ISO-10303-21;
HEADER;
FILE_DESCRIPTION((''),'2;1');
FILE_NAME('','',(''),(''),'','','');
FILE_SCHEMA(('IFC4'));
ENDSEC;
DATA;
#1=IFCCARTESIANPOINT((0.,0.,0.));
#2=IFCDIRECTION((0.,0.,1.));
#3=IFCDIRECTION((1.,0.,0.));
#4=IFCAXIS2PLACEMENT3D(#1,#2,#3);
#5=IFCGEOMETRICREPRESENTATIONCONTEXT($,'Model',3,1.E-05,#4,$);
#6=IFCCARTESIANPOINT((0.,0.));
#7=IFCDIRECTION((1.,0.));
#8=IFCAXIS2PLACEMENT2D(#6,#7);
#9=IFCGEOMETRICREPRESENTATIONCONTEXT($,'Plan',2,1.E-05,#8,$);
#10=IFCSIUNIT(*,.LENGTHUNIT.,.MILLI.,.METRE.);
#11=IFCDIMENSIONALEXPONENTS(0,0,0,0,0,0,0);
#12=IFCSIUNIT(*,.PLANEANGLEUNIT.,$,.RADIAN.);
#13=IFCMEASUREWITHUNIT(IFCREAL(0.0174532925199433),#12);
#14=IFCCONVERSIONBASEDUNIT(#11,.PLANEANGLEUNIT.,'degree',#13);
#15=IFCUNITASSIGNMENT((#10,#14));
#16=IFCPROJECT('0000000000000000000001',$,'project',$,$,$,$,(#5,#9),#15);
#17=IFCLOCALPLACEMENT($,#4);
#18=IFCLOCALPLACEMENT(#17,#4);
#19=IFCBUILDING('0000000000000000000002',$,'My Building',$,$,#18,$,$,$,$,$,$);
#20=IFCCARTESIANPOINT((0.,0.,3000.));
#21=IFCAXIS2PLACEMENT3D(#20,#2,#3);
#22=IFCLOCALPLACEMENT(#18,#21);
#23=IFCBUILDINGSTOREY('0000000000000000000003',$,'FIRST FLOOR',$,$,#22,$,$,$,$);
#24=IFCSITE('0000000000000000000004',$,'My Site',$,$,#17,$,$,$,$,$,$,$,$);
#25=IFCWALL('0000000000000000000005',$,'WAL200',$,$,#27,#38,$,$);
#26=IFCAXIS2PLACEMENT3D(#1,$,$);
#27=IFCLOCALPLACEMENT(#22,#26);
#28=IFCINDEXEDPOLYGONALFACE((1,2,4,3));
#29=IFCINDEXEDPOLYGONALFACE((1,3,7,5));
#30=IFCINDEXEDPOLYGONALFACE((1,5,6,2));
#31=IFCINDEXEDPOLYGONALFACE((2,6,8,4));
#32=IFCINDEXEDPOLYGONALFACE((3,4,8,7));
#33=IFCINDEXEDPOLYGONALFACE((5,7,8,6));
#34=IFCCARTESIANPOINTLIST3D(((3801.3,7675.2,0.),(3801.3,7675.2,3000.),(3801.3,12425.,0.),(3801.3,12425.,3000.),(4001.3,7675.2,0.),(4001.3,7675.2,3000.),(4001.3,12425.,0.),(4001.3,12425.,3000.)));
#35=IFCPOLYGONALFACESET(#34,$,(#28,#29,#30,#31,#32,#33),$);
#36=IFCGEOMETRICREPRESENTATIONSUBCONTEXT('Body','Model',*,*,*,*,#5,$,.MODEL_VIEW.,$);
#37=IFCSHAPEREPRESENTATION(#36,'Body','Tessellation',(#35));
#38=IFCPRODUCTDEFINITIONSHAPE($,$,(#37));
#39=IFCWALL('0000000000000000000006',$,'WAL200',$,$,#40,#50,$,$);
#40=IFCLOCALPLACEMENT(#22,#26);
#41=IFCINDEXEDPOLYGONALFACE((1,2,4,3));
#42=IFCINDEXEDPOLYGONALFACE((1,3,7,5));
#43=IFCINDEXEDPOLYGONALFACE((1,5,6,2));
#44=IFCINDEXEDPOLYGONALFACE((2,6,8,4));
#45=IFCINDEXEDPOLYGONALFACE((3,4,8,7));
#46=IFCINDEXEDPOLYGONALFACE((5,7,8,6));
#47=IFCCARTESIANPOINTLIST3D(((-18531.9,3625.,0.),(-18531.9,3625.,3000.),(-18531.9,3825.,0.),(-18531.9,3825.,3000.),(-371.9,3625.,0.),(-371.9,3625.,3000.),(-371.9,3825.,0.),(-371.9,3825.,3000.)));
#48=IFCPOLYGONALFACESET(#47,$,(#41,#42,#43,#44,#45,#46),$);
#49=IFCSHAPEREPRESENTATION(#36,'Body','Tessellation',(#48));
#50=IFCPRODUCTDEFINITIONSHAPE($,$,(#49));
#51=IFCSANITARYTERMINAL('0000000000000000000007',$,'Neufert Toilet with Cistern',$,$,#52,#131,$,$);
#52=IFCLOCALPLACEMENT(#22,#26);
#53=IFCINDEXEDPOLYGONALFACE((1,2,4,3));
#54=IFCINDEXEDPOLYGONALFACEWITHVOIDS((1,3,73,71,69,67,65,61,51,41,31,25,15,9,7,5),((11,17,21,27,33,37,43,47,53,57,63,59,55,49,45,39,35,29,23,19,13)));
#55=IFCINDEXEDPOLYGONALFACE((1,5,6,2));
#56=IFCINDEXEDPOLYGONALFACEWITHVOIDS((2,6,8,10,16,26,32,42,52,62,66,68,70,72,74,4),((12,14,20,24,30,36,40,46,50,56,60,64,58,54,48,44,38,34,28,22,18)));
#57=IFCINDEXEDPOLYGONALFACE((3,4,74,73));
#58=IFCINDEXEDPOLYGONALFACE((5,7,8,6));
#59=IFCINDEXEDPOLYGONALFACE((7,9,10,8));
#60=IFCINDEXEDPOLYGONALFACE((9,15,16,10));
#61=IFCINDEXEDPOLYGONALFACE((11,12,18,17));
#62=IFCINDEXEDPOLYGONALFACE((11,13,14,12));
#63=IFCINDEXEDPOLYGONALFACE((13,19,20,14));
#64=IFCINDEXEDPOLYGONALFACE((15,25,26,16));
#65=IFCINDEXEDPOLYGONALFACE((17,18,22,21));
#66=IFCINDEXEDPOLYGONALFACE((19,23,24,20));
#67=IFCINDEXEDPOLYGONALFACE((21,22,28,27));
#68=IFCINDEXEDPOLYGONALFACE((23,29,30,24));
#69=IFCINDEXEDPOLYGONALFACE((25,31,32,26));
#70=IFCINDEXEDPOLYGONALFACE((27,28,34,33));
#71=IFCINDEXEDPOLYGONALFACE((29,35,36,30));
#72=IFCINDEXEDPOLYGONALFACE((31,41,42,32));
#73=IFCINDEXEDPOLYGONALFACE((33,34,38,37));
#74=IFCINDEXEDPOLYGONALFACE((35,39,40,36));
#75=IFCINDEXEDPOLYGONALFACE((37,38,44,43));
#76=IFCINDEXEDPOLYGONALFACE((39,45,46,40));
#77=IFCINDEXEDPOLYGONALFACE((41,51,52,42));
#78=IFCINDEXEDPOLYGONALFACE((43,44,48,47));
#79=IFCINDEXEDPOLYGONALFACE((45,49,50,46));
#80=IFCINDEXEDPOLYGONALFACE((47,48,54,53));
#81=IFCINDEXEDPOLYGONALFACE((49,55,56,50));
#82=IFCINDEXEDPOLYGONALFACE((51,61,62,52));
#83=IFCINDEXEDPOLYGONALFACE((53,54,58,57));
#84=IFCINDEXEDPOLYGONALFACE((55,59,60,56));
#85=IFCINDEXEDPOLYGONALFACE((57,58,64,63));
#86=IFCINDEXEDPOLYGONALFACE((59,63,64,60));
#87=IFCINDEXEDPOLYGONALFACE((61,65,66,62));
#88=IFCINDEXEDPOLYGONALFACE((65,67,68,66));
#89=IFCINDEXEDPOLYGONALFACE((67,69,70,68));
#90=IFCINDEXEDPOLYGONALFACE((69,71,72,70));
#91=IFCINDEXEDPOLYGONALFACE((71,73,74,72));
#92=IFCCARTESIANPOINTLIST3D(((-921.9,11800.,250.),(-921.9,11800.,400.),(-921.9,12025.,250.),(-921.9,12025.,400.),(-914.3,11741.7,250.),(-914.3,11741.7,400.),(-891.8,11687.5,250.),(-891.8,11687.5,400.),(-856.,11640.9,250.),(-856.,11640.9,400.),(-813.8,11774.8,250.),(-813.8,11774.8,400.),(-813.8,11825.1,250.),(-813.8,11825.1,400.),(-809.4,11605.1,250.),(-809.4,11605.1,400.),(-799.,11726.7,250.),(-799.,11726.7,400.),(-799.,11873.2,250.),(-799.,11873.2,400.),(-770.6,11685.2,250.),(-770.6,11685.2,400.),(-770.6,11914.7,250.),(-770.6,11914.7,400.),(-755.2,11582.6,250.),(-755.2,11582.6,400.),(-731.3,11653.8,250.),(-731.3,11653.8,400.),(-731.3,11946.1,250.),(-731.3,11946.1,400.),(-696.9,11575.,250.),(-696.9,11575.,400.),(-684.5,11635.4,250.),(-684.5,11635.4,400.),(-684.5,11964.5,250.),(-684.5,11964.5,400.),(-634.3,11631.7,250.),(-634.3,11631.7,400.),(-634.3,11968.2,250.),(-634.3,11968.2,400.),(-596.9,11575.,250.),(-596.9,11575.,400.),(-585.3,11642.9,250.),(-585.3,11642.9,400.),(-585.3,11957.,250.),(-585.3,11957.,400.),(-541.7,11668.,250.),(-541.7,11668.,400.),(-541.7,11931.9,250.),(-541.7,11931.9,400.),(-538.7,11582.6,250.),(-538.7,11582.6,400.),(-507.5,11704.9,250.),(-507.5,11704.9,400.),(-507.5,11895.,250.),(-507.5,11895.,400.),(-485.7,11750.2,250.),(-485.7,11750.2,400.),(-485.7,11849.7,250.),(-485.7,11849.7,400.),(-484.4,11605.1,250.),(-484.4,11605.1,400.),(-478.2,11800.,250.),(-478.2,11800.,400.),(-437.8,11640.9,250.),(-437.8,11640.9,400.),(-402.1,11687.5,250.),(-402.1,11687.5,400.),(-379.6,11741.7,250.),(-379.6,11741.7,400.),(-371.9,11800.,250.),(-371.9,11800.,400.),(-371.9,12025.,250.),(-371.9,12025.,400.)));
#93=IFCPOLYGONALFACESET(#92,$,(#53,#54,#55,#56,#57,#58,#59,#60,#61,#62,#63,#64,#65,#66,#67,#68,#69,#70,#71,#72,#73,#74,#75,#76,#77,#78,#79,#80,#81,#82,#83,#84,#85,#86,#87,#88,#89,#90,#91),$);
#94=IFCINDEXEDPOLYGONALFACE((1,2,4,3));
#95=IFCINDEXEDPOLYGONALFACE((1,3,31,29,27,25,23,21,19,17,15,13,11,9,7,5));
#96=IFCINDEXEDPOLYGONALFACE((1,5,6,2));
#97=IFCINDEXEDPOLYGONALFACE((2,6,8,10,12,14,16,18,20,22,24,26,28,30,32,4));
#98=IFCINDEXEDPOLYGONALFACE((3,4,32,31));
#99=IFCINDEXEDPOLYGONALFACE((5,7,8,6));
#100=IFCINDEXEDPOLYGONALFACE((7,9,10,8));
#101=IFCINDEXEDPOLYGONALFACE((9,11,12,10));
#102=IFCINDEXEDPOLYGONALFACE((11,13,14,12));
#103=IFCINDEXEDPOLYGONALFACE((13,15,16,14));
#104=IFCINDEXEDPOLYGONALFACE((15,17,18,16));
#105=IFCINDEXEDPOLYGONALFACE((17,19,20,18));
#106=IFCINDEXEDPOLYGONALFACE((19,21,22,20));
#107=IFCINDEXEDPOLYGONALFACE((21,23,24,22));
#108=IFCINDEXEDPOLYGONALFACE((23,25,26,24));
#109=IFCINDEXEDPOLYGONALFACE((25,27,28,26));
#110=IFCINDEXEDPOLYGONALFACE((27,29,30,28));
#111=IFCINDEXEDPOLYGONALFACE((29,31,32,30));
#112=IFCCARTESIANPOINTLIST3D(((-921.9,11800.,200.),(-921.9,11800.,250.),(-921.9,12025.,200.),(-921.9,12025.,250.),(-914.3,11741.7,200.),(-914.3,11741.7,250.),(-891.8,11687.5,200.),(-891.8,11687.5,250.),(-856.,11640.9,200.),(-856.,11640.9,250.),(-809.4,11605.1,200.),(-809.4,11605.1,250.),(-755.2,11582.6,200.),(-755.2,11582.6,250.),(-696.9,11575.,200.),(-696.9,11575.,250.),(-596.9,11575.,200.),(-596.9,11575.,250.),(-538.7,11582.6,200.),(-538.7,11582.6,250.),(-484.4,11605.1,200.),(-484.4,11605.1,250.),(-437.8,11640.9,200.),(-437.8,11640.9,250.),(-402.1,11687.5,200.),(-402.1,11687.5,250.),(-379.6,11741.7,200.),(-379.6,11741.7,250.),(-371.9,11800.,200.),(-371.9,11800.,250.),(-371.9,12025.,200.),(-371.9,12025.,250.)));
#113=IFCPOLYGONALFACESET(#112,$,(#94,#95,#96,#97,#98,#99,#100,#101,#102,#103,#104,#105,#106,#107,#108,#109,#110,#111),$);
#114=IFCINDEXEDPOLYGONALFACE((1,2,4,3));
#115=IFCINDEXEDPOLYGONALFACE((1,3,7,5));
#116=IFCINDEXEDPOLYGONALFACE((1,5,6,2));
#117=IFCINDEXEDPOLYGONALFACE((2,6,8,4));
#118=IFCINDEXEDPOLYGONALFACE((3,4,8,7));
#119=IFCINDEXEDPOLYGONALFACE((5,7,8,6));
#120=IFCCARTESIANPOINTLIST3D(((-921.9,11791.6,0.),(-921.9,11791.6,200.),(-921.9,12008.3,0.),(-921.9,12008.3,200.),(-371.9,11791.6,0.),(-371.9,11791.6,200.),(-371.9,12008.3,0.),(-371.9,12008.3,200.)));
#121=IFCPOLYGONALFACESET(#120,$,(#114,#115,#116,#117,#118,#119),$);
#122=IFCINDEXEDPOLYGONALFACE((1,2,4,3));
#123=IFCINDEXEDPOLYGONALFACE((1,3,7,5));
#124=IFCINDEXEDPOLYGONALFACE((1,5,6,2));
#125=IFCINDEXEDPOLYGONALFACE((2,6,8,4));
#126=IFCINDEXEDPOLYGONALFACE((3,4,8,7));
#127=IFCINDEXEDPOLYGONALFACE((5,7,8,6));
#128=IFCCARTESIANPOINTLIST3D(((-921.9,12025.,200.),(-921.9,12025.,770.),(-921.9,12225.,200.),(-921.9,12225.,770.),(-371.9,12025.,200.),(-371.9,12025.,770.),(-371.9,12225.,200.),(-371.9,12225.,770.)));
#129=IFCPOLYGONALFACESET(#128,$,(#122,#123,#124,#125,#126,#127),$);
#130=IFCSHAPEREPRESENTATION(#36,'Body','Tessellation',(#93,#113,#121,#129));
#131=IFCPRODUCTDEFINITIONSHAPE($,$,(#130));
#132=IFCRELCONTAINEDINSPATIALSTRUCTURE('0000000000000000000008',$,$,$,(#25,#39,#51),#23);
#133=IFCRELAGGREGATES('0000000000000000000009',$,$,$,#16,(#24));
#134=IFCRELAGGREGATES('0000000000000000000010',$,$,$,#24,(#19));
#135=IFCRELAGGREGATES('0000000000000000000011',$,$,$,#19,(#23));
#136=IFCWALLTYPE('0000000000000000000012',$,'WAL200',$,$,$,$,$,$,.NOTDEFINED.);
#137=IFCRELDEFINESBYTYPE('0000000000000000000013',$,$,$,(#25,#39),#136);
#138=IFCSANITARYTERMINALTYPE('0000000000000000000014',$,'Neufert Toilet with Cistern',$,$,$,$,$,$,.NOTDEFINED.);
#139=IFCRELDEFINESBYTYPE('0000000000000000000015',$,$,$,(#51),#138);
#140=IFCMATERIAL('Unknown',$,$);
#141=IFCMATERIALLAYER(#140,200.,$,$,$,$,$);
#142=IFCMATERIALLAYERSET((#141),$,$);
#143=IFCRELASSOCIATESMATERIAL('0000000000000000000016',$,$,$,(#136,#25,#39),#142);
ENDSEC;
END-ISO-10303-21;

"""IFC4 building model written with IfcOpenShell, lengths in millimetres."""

from ifc_helpers import new_model, entity, si_unit, converted_unit, frame, frame_2d, origin_with_axes, origin_2d_with_axis, place, context, subcontext, project, spatial, line, arc, indexed_curve, circle_curve, outline, extrude, shape, source, transform, mapped, material, layer, layer_set, layer_usage, type_object, type_shapes, element, save


model = new_model("IFC4")

# Units and contexts
model_context = context("Model", 3, precision=1e-05, world=origin_with_axes())
plan_context = context("Plan", 2, precision=1e-05, world=origin_2d_with_axis())
body_context_1 = subcontext(model_context, "Body", "Model", "MODEL_VIEW")
body_context_2 = subcontext(plan_context, "Body", "Plan", "PLAN_VIEW")
ifc_project = project(units=[si_unit("LENGTHUNIT", "METRE", prefix="MILLI"), converted_unit("PLANEANGLEUNIT", "degree", entity("IfcReal", 0.0174532925199433), si_unit("PLANEANGLEUNIT", "RADIAN"), dimensions=[0, 0, 0, 0, 0, 0, 0])], contexts=[model_context, plan_context])

# Site, building, storey
site_placement = place(None, origin_with_axes())
site = spatial("IfcSite", under=ifc_project, at=site_placement, Name="My Site")
building_placement = place(site_placement, origin_with_axes())
building = spatial("IfcBuilding", under=site, at=building_placement, Name="My Building")
storey_placement = place(building_placement, frame((0.0, 0.0, 3000.0), z_axis=(0.0, 0.0, 1.0), x_axis=(1.0, 0.0, 0.0)))
storey = spatial("IfcBuildingStorey", under=building, at=storey_placement, Name="FIRST FLOOR")

# Shared definitions
ifc_material = material(Name="Unknown")

# Walls
ifc_layer_1 = layer(ifc_material, 200.0)
ifc_layer_set_1 = layer_set([ifc_layer_1])
wall_type_1 = type_object("IfcWallType", Name="WAL200", PredefinedType="NOTDEFINED", material=ifc_layer_set_1)
ifc_layer_usage_1 = layer_usage(ifc_layer_set_1, "AXIS2", "POSITIVE", 0.0)
wall_1_placement = place(storey_placement, frame((3801.3, 12425.0, 0.0), z_axis=(0.0, 0.0, 1.0), x_axis=(-0.000001, -1.0, 0.0)))
element("IfcWall", 1, at=wall_1_placement, inside=storey, type_object=wall_type_1, material=ifc_layer_usage_1, Name="WAL200", context=body_context_1, shape_type="SweptSolid", body=[
    extrude(outline(indexed_curve([(0.0, 0.0), (0.0, 200.0), (4749.8, 200.0), (4749.8, 0.0), (0.0, 0.0)], self_intersect=False)), origin_with_axes(), (0.0, 0.0, 1.0), 3000.0),
])
ifc_layer_usage_2 = layer_usage(ifc_layer_set_1, "AXIS2", "POSITIVE", 0.0)
wall_2_placement = place(storey_placement, frame((-371.9, 3825.0, 0.0), z_axis=(0.0, 0.0, 1.0), x_axis=(-1.0, 0.0, 0.0)))
element("IfcWall", 2, at=wall_2_placement, inside=storey, type_object=wall_type_1, material=ifc_layer_usage_2, Name="WAL200", context=body_context_1, shape_type="SweptSolid", body=[
    extrude(outline(indexed_curve([(0.0, 0.0), (0.0, 200.0), (18160.0, 200.0), (18160.0, 0.0), (0.0, 0.0)], self_intersect=False)), origin_with_axes(), (0.0, 0.0, 1.0), 3000.0),
])

# Sanitary terminal
sanitary_terminal_type_1 = type_object("IfcSanitaryTerminalType", Name="Neufert Toilet with Cistern", PredefinedType="NOTDEFINED")
shared_shape_1 = source(origin_with_axes(), body_context_1, "Body", "SweptSolid", [
    extrude(outline(indexed_curve([(-275.0, -200.0), (275.0, -200.0), (275.0, -425.0), (209.1, -584.1), (50.0, -650.0), (-50.0, -650.0), (-209.1, -584.1), (-275.0, -425.0)], segments=[line(1, 2), line(2, 3), arc(3, 4, 5), line(5, 6), arc(6, 7, 8), line(8, 1)]), holes=[circle_curve(frame_2d((0.0, -425.0)), 168.8)]), frame((0.0, 0.0, 250.0), z_axis=(0.0, 0.0, 1.0), x_axis=(1.0, 0.0, 0.0)), (0.0, 0.0, 1.0), 150.0),
    extrude(outline(indexed_curve([(-275.0, -200.0), (275.0, -200.0), (275.0, -425.0), (209.1, -584.1), (50.0, -650.0), (-50.0, -650.0), (-209.1, -584.1), (-275.0, -425.0)], segments=[line(1, 2), line(2, 3), arc(3, 4, 5), line(5, 6), arc(6, 7, 8), line(8, 1)])), frame((0.0, 0.0, 200.0), z_axis=(0.0, 0.0, 1.0), x_axis=(1.0, 0.0, 0.0)), (0.0, 0.0, 1.0), 50.0),
    extrude(outline(indexed_curve([(-275.0, -216.7), (275.0, -216.7), (275.0, -433.3), (-275.0, -433.3)], segments=[line(1, 2), line(2, 3), line(3, 4), line(4, 1)])), origin_with_axes(), (0.0, 0.0, 1.0), 200.0),
    extrude(outline(indexed_curve([(-275.0, 0.0), (275.0, 0.0), (275.0, -200.0), (-275.0, -200.0)], segments=[line(1, 2), line(2, 3), line(3, 4), line(4, 1)])), frame((0.0, 0.0, 200.0), z_axis=(0.0, 0.0, 1.0), x_axis=(1.0, 0.0, 0.0)), (0.0, 0.0, 1.0), 570.0),
])
shared_shape_2 = source(origin_with_axes(), body_context_2, "Body", "Curve2D", [
    entity("IfcIndexedPolyCurve", entity("IfcCartesianPointList2D", [[-275.0, 0.0], [275.0, 0.0], [275.0, -200.0], [-275.0, -200.0]]), [entity("IfcLineIndex", [1, 2]), entity("IfcLineIndex", [2, 3]), entity("IfcLineIndex", [3, 4]), entity("IfcLineIndex", [4, 1])]),
    entity("IfcIndexedPolyCurve", entity("IfcCartesianPointList2D", [[165.0, -200.0], [192.5, -335.0]]), [entity("IfcLineIndex", [1, 2])]),
    entity("IfcTrimmedCurve", entity("IfcEllipse", entity("IfcAxis2Placement2D", entity("IfcCartesianPoint", [0.0, -335.0]), entity("IfcDirection", [1.0, 0.0])), 192.5, 315.0), [entity("IfcCartesianPoint", [-192.5, -335.0])], [entity("IfcCartesianPoint", [192.5, -335.0])], True, "CARTESIAN"),
    entity("IfcIndexedPolyCurve", entity("IfcCartesianPointList2D", [[-165.0, -200.0], [-192.5, -335.0]]), [entity("IfcLineIndex", [1, 2])]),
    entity("IfcEllipse", entity("IfcAxis2Placement2D", entity("IfcCartesianPoint", [0.0, -452.0]), entity("IfcDirection", [1.0, 0.0])), 131.2, 157.5),
    entity("IfcIndexedPolyCurve", entity("IfcCartesianPointList2D", [[-34.4, -452.0], [-34.4, -429.5], [34.4, -429.5], [34.4, -452.0]]), [entity("IfcLineIndex", [1, 2]), entity("IfcLineIndex", [2, 3]), entity("IfcLineIndex", [3, 4])]),
    entity("IfcTrimmedCurve", entity("IfcEllipse", entity("IfcAxis2Placement2D", entity("IfcCartesianPoint", [0.0, -452.0]), entity("IfcDirection", [1.0, 0.0])), 34.4, 22.5), [entity("IfcCartesianPoint", [-34.4, -452.0])], [entity("IfcCartesianPoint", [34.4, -452.0])], True, "CARTESIAN"),
])
type_shapes(sanitary_terminal_type_1, [shared_shape_1, shared_shape_2])
sanitary_terminal_1_placement = place(storey_placement, frame((-646.9, 12225.0, 0.0), z_axis=(0.0, 0.0, 1.0), x_axis=(1.0, 0.0, 0.0)))
element("IfcSanitaryTerminal", 3, at=sanitary_terminal_1_placement, inside=storey, type_object=sanitary_terminal_type_1, Name="Neufert Toilet with Cistern", shapes=[
    shape(body_context_1, "Body", "MappedRepresentation", [mapped(shared_shape_1, transform((0.0, 0.0, 0.0), x_axis=(1.0, 0.0, 0.0), y_axis=(0.0, 1.0, 0.0), z_axis=(0.0, 0.0, 1.0), scale=1.0))]),
    shape(body_context_2, "Body", "MappedRepresentation", [mapped(shared_shape_2, transform((0.0, 0.0, 0.0), x_axis=(1.0, 0.0, 0.0), y_axis=(0.0, 1.0, 0.0), z_axis=(0.0, 0.0, 1.0), scale=1.0))]),
])

save(model, "model.ifc")
